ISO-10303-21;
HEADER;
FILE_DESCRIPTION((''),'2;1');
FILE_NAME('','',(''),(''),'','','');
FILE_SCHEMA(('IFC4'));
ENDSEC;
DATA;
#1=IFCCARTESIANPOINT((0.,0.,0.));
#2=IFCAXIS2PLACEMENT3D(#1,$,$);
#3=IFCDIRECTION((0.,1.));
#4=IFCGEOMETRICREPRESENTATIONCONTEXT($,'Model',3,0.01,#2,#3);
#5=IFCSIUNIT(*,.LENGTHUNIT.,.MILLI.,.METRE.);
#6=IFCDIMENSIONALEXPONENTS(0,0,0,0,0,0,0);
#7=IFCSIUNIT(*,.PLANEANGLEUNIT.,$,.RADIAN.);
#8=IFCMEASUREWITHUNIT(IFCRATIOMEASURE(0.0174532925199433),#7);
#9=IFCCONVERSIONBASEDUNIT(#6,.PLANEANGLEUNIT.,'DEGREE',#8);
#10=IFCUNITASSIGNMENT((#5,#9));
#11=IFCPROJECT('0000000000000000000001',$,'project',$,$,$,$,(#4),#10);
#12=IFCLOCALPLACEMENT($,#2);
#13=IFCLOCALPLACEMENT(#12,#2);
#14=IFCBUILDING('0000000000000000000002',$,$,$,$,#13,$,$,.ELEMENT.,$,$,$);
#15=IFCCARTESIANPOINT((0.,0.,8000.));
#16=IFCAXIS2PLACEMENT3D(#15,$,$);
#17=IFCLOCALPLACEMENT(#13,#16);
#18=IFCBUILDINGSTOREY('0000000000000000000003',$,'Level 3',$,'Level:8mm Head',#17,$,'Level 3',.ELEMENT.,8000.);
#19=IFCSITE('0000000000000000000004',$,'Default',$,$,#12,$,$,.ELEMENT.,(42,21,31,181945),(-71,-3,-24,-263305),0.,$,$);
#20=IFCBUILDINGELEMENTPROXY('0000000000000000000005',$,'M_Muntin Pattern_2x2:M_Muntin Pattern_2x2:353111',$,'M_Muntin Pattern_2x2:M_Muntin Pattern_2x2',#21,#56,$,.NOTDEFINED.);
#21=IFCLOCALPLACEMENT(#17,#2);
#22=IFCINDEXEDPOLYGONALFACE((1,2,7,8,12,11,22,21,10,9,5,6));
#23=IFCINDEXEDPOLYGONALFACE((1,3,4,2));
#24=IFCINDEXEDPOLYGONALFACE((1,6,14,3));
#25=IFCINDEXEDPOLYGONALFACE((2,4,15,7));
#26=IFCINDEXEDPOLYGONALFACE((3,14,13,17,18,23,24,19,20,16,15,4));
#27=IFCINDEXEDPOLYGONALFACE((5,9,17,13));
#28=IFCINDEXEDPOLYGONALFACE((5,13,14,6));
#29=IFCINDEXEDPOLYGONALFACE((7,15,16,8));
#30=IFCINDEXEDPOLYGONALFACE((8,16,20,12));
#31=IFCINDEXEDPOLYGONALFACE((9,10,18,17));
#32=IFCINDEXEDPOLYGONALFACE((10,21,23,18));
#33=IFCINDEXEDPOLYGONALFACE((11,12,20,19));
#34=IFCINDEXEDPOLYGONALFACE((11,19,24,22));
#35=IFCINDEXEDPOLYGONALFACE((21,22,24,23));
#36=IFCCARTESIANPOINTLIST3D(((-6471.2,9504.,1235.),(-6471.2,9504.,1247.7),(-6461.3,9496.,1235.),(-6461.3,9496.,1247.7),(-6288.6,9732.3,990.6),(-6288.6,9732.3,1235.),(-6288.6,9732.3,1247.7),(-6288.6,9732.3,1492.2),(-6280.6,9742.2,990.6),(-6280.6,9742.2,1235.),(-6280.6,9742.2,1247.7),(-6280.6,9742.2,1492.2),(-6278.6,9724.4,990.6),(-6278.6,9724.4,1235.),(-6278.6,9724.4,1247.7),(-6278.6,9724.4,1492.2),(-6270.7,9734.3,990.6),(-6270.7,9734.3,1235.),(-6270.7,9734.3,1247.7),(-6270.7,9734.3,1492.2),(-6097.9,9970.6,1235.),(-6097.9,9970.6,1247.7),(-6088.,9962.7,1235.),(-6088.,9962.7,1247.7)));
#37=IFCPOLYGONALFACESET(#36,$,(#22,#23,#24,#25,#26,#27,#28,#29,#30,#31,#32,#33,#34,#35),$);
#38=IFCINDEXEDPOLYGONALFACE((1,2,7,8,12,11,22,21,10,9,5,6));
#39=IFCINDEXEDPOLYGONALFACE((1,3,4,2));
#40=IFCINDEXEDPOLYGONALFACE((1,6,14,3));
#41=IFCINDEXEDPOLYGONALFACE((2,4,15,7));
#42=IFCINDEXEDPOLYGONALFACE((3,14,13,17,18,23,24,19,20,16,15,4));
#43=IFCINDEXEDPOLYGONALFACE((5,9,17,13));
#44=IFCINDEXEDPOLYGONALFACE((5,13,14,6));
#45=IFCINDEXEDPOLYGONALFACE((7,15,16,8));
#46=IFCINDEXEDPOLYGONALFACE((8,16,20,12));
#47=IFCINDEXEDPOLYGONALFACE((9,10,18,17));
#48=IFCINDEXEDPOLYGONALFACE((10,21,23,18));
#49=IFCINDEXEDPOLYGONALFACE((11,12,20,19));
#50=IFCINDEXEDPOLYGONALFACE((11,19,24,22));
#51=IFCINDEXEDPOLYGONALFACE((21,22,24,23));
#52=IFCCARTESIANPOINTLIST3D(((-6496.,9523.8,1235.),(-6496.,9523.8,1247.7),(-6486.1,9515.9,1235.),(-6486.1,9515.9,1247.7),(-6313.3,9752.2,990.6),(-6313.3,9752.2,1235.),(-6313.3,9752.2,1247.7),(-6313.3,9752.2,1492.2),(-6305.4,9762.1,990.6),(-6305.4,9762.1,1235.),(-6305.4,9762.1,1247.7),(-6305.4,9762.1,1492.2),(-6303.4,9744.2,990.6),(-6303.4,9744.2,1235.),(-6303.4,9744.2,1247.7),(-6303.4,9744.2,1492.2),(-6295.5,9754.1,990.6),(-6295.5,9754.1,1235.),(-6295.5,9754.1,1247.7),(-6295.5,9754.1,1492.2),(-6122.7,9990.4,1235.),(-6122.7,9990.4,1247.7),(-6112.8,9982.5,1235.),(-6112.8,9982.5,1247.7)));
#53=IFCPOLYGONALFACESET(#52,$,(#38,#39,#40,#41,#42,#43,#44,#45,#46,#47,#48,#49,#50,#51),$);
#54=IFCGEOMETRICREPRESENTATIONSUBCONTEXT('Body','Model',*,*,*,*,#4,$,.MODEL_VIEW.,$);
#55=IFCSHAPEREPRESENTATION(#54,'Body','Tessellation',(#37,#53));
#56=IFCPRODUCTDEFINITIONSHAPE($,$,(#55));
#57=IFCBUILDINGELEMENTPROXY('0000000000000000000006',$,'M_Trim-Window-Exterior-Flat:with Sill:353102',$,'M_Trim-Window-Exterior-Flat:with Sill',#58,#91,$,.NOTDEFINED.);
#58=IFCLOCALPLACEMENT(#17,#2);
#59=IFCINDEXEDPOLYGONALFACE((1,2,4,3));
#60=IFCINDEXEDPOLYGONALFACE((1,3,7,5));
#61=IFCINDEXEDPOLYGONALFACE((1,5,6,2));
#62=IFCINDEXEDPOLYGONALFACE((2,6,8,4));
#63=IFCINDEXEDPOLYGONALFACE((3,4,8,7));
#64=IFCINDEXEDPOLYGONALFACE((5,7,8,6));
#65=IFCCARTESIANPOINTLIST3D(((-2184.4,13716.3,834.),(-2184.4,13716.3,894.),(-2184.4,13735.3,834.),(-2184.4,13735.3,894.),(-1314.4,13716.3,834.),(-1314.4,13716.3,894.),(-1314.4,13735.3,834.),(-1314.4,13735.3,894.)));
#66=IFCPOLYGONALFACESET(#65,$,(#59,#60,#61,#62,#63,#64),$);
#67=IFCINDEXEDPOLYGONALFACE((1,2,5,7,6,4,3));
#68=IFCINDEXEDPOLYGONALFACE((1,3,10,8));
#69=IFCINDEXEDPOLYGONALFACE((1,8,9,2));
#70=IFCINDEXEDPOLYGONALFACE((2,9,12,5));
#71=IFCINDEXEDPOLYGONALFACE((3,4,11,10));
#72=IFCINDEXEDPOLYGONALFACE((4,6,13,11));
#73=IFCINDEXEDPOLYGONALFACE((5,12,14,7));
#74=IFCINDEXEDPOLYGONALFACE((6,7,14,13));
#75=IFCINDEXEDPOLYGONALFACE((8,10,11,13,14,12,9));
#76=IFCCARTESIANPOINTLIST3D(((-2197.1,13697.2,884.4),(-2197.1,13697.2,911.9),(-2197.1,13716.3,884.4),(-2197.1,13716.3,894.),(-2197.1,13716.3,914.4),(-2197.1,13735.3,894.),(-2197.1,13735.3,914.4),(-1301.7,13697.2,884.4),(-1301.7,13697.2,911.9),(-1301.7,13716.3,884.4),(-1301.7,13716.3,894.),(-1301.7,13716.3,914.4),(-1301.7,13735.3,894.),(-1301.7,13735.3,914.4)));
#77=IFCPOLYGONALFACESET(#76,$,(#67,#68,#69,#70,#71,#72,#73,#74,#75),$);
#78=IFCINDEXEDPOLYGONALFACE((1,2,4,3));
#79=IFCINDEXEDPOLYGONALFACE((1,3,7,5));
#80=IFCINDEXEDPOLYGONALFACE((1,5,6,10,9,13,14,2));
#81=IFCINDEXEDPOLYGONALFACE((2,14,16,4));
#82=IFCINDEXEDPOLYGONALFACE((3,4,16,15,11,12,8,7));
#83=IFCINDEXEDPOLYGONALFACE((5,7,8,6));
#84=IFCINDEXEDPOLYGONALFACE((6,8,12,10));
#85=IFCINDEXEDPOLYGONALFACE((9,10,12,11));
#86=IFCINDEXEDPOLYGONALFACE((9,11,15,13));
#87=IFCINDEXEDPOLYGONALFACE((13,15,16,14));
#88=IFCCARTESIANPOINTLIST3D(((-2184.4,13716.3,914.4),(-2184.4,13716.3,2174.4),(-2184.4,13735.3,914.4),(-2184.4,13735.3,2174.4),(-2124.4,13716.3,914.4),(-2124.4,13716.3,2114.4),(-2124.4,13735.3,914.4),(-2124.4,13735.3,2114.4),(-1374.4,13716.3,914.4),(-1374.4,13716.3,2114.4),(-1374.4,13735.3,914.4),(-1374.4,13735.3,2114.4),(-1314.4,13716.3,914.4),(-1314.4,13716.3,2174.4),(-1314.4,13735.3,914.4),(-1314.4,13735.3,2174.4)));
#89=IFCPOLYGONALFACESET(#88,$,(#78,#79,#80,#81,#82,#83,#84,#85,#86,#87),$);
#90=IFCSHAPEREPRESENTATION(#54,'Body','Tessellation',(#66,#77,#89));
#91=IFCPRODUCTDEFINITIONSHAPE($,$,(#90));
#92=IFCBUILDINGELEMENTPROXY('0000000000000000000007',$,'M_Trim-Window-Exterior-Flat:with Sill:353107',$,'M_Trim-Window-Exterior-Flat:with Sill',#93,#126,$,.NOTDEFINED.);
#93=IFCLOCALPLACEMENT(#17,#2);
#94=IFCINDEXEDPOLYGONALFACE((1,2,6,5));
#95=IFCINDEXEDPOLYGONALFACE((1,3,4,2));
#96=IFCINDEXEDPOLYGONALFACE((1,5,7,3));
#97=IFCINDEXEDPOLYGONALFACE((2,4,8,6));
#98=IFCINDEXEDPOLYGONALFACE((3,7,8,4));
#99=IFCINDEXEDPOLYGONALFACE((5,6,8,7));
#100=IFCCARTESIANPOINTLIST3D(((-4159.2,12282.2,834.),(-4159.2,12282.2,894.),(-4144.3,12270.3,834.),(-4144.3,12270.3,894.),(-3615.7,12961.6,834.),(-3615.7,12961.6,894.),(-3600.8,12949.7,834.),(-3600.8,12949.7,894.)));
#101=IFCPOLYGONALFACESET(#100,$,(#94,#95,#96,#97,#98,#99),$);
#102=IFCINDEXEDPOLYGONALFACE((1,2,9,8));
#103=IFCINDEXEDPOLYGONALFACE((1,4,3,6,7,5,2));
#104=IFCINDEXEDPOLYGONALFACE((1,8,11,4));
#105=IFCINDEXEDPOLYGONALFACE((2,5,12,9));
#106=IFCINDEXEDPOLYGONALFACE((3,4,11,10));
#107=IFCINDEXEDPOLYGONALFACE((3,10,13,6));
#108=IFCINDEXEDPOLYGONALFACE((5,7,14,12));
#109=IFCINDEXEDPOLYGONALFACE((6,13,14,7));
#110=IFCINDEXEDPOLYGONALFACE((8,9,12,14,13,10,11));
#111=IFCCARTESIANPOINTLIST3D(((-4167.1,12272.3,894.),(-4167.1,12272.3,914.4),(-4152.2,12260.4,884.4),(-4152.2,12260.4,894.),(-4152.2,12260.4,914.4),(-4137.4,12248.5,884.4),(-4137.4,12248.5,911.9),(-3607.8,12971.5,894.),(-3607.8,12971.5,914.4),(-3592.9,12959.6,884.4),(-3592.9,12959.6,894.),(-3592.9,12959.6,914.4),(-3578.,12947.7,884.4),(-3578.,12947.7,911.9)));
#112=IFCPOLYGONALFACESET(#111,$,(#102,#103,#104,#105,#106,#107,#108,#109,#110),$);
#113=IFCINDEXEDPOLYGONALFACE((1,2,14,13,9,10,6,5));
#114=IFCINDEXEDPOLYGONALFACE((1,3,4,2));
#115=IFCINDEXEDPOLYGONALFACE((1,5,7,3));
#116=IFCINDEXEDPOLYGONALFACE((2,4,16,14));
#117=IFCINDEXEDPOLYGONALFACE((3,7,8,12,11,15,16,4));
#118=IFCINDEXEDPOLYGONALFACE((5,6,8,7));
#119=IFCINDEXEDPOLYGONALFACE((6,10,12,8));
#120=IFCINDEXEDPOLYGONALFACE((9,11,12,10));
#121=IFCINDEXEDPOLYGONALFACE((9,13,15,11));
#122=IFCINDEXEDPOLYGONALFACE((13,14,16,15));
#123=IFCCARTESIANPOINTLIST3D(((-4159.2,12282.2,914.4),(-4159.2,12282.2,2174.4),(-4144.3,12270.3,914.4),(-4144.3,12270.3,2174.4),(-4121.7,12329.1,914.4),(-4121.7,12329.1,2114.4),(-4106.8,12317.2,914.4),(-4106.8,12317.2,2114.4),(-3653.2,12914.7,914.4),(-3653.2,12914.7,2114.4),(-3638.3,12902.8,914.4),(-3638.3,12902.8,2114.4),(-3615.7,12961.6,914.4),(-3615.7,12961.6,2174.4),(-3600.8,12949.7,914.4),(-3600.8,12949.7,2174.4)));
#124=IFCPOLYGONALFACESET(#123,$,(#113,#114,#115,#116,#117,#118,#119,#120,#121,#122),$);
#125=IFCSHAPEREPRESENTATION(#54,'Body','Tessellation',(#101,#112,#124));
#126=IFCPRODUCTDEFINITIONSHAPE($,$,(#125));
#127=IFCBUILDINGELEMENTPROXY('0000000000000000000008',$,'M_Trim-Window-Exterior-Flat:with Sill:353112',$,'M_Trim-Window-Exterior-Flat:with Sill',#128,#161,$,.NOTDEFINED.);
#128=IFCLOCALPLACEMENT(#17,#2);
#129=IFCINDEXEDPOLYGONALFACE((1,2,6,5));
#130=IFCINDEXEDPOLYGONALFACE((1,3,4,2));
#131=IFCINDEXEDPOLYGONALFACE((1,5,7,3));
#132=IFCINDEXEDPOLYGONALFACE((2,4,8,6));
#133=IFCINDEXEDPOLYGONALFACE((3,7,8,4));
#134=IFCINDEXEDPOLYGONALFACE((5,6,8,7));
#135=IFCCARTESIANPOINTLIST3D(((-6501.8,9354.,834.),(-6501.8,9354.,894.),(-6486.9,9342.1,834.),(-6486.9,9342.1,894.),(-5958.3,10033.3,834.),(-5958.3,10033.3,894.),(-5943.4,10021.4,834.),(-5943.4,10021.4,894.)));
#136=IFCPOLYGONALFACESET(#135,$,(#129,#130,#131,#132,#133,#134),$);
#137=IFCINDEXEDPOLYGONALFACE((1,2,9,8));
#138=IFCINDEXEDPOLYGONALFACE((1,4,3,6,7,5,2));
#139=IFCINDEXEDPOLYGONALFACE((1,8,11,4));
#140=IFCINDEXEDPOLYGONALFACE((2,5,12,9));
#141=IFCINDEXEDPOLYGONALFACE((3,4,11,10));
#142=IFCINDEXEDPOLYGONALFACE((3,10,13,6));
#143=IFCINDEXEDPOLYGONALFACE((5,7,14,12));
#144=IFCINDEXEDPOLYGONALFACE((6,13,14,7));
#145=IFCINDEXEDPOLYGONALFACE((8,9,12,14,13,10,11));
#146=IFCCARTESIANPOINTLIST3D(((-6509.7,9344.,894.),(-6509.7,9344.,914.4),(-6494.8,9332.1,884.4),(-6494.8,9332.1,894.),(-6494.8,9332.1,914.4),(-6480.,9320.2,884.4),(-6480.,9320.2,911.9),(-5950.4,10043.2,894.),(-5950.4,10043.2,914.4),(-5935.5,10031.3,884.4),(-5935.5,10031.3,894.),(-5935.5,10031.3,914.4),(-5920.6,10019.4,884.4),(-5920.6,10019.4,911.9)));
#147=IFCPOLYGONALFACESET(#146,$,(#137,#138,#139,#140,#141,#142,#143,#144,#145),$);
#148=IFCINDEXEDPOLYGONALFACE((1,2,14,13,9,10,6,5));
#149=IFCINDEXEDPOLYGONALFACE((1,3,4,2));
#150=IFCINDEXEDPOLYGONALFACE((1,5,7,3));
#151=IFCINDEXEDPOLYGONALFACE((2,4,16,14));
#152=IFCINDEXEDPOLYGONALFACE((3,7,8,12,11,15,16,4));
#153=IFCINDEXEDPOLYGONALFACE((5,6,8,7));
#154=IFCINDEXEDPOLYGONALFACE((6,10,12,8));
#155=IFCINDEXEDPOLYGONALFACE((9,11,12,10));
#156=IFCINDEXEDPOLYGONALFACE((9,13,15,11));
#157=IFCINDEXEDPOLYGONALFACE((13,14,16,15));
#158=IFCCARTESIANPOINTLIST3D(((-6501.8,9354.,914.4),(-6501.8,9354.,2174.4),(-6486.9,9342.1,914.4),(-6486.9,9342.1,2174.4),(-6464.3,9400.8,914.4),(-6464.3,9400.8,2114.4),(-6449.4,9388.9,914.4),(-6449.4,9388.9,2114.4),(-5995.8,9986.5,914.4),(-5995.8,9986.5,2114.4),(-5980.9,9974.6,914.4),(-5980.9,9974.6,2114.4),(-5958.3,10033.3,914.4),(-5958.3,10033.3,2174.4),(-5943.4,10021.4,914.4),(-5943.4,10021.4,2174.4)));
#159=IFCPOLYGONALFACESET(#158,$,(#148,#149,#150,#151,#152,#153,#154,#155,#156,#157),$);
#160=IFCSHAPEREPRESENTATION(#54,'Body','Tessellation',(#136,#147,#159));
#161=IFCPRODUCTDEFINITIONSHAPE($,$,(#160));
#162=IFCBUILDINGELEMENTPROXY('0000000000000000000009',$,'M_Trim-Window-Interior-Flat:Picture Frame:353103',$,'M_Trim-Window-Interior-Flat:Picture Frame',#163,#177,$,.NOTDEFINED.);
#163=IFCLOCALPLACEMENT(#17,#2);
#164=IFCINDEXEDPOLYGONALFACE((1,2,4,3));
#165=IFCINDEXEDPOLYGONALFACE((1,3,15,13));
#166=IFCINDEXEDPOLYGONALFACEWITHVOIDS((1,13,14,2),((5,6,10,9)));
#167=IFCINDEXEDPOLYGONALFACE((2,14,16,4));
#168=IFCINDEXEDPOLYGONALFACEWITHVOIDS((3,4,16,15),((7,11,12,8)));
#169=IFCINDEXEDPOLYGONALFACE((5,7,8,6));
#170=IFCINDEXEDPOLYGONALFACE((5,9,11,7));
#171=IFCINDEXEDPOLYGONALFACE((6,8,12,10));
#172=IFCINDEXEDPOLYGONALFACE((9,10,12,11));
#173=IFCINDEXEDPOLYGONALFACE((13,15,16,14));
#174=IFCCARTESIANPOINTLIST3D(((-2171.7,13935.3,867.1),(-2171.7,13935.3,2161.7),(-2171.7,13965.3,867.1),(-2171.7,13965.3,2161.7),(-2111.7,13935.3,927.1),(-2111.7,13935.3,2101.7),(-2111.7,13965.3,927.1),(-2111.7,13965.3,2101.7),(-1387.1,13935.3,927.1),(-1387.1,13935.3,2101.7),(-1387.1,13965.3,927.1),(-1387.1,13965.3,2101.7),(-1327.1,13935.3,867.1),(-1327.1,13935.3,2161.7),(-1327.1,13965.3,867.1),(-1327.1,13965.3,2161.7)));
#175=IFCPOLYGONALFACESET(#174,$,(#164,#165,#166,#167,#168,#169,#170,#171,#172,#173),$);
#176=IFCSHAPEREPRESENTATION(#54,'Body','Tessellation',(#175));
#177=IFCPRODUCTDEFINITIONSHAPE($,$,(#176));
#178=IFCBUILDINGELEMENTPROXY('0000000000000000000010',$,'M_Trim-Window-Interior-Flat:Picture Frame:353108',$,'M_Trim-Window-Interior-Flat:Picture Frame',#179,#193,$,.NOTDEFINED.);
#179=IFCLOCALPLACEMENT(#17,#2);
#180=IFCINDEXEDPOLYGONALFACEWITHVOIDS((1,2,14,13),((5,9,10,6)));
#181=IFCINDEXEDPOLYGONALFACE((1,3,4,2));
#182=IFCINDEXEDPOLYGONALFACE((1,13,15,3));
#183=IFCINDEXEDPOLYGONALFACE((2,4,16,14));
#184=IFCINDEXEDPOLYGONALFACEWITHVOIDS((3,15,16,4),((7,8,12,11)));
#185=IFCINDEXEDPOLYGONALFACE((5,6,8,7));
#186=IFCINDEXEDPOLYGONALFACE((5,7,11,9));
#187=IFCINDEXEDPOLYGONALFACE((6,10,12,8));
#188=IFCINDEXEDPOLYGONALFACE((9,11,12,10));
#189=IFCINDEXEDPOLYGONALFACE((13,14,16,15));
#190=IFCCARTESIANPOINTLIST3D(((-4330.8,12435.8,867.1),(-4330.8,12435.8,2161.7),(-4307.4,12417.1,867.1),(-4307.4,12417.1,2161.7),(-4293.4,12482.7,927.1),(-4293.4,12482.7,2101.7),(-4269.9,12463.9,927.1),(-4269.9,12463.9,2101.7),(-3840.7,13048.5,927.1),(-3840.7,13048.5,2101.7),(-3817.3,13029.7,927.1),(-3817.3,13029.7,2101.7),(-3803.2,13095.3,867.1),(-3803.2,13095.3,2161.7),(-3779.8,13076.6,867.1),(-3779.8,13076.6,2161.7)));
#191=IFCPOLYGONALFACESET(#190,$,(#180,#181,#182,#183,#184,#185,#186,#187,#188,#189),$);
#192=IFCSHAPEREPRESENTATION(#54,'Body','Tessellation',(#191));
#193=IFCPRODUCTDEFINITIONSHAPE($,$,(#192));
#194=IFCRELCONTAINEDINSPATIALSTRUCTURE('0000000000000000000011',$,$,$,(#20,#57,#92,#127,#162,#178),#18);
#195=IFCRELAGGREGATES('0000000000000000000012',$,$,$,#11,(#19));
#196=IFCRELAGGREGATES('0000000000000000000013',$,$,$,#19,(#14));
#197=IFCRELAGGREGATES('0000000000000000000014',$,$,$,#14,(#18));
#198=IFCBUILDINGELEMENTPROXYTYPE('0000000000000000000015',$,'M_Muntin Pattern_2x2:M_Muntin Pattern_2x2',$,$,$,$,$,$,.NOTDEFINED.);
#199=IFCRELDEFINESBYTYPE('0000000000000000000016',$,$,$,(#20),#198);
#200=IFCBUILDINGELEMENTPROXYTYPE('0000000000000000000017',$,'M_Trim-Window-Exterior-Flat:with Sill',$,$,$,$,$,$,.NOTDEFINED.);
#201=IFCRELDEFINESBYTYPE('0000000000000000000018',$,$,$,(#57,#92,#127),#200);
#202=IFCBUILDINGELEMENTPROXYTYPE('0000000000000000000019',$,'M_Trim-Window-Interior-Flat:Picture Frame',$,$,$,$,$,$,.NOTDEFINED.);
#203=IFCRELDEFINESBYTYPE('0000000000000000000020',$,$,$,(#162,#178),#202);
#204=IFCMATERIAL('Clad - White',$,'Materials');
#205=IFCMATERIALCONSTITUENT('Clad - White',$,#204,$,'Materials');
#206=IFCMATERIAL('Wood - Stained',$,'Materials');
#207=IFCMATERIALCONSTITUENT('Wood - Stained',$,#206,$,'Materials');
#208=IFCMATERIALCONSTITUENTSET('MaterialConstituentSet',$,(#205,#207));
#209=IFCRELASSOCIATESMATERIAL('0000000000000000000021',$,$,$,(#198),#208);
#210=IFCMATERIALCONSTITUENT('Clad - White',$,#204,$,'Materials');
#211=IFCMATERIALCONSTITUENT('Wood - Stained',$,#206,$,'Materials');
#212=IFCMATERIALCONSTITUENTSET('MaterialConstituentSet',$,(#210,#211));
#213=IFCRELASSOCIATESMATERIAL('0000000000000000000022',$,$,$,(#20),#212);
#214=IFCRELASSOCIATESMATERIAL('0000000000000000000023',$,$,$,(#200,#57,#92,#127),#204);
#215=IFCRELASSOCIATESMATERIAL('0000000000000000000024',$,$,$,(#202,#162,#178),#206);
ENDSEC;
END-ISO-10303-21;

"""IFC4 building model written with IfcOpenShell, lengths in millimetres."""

from ifc_helpers import new_model, entity, si_unit, converted_unit, direction, frame, frame_2d, origin, place, context, subcontext, project, spatial, polyline, rectangle, outline, extrude, source, transform, mapped, material, constituent, constituent_set, type_object, type_shapes, element, save


model = new_model("IFC4")

# Units and contexts
model_context = context("Model", 3, precision=0.01, world=origin(), true_north=direction((0.0, 1.0)))
body_context = subcontext(model_context, "Body", "Model", "MODEL_VIEW")
ifc_project = project(units=[si_unit("LENGTHUNIT", "METRE", prefix="MILLI"), converted_unit("PLANEANGLEUNIT", "DEGREE", entity("IfcRatioMeasure", 0.0174532925199433), si_unit("PLANEANGLEUNIT", "RADIAN"), dimensions=[0, 0, 0, 0, 0, 0, 0])], contexts=[model_context])

# Site, building, storey
site_placement = place(None, origin())
site = spatial("IfcSite", under=ifc_project, at=site_placement, Name="Default", CompositionType="ELEMENT", RefLatitude=(42, 21, 31, 181945), RefLongitude=(-71, -3, -24, -263305), RefElevation=0.0)
building_placement = place(site_placement, origin())
building = spatial("IfcBuilding", under=site, at=building_placement, CompositionType="ELEMENT")
storey_placement = place(building_placement, frame((0.0, 0.0, 8000.0)))
storey = spatial("IfcBuildingStorey", under=building, at=storey_placement, Name="Level 3", ObjectType="Level:8mm Head", LongName="Level 3", CompositionType="ELEMENT", Elevation=8000.0)

# Shared definitions
ifc_material_1 = material(Name="Wood - Stained", Category="Materials")

# Building element proxies
ifc_material_2 = material(Name="Clad - White", Category="Materials")
ifc_constituent_1 = constituent(ifc_material_2, Name="Clad - White", Category="Materials")
ifc_constituent_2 = constituent(ifc_material_1, Name="Wood - Stained", Category="Materials")
ifc_constituent_set_1 = constituent_set(constituents=[ifc_constituent_1, ifc_constituent_2], Name="MaterialConstituentSet")
building_element_proxy_type_1 = type_object("IfcBuildingElementProxyType", Name="M_Muntin Pattern_2x2:M_Muntin Pattern_2x2", PredefinedType="NOTDEFINED", material=ifc_constituent_set_1)
shared_shape_1 = source(origin(), body_context, "Body", "SweptSolid", [
    extrude(outline(polyline([(6.4, -6.4), (250.8, -6.4), (250.8, 6.3), (6.4, 6.3), (6.4, 298.8), (-6.3, 298.8), (-6.3, 6.3), (-250.8, 6.3), (-250.8, -6.4), (-6.3, -6.4), (-6.3, -298.8), (6.4, -298.8), (6.4, -6.4)])), frame((0.0, 9.5, 250.8), z_axis=(0.0, 1.0, 0.0), x_axis=(0.0, 0.0, 1.0)), (0.0, 0.0, 1.0), 12.7),
    extrude(outline(polyline([(6.4, -6.4), (250.8, -6.4), (250.8, 6.3), (6.4, 6.3), (6.4, 298.8), (-6.3, 298.8), (-6.3, 6.3), (-250.8, 6.3), (-250.8, -6.4), (-6.3, -6.4), (-6.3, -298.8), (6.4, -298.8), (6.4, -6.4)])), frame((0.0, -22.2, 250.8), z_axis=(0.0, 1.0, 0.0), x_axis=(0.0, 0.0, 1.0)), (0.0, 0.0, 1.0), 12.7),
])
type_shapes(building_element_proxy_type_1, [shared_shape_1])
ifc_constituent_3 = constituent(ifc_material_2, Name="Clad - White", Category="Materials")
ifc_constituent_4 = constituent(ifc_material_1, Name="Wood - Stained", Category="Materials")
ifc_constituent_set_2 = constituent_set(constituents=[ifc_constituent_3, ifc_constituent_4], Name="MaterialConstituentSet")
proxy_1_placement = place(storey_placement, frame((-6292.0, 9743.2, 990.6), z_axis=(0.0, 0.0, 1.0), x_axis=(-0.624695, -0.780869, 0.0)))
element("IfcBuildingElementProxy", 1, at=proxy_1_placement, inside=storey, type_object=building_element_proxy_type_1, material=ifc_constituent_set_2, Name="M_Muntin Pattern_2x2:M_Muntin Pattern_2x2:353111", ObjectType="M_Muntin Pattern_2x2:M_Muntin Pattern_2x2", PredefinedType="NOTDEFINED", context=body_context, shape_type="MappedRepresentation", body=[
    mapped(shared_shape_1, transform((0.0, 0.0, 0.0), scale=1.0)),
])
building_element_proxy_type_2 = type_object("IfcBuildingElementProxyType", Name="M_Trim-Window-Exterior-Flat:with Sill", PredefinedType="NOTDEFINED", material=ifc_material_2)
shared_shape_2 = source(origin(), body_context, "Body", "SweptSolid", [
    extrude(rectangle(XDim=870.0, YDim=60.0, at=frame_2d((0.0, 0.0), x_axis=(1.0, 0.0))), frame((0.0, -1250.4, 0.0), z_axis=(0.0, 0.0, 1.0), x_axis=(-1.0, 0.0, 0.0)), (0.0, 0.0, 1.0), 19.1),
    extrude(outline(polyline([(-19.0, -15.2), (0.0, -15.2), (0.0, -5.7), (19.0, -5.7), (19.0, 14.8), (0.0, 14.8), (-19.0, 12.3), (-19.0, -15.2)])), frame((-447.7, -1214.8, 19.0), z_axis=(1.0, 0.0, 0.0), x_axis=(0.0, 0.0, -1.0)), (0.0, 0.0, 1.0), 895.4),
    extrude(outline(polyline([(-645.0, -435.0), (615.0, -435.0), (615.0, -375.0), (-585.0, -375.0), (-585.0, 375.0), (615.0, 375.0), (615.0, 435.0), (-645.0, 435.0), (-645.0, -435.0)])), frame((0.0, -585.0, 0.0), z_axis=(0.0, 0.0, 1.0), x_axis=(0.0, -1.0, 0.0)), (0.0, 0.0, 1.0), 19.1),
])
type_shapes(building_element_proxy_type_2, [shared_shape_2])
for number, where, z_axis, x_axis, name in (
    (2, (-1749.4, 13735.3, 2114.4), (0.0, -1.0, 0.0), (1.0, 0.0, 0.0), "M_Trim-Window-Exterior-Flat:with Sill:353102"),
    (3, (-3887.4, 12621.9, 2114.4), (0.780869, -0.624695, 0.0), (0.624695, 0.780869, 0.0), "M_Trim-Window-Exterior-Flat:with Sill:353107"),
    (4, (-6230.0, 9693.6, 2114.4), (0.780869, -0.624695, 0.0), (0.624695, 0.780869, 0.0), "M_Trim-Window-Exterior-Flat:with Sill:353112"),
):
    element("IfcBuildingElementProxy", number, at=place(storey_placement, frame(where, z_axis=z_axis, x_axis=x_axis)), inside=storey, type_object=building_element_proxy_type_2, material=ifc_material_2, Name=name, ObjectType="M_Trim-Window-Exterior-Flat:with Sill", PredefinedType="NOTDEFINED", context=body_context, shape_type="MappedRepresentation", body=[
        mapped(shared_shape_2, transform((0.0, 0.0, 0.0), scale=1.0)),
    ])
building_element_proxy_type_3 = type_object("IfcBuildingElementProxyType", Name="M_Trim-Window-Interior-Flat:Picture Frame", PredefinedType="NOTDEFINED", material=ifc_material_1)
shared_shape_3 = source(origin(), body_context, "Body", "SweptSolid", [
    extrude(outline(polyline([(-422.3, -647.3), (422.3, -647.3), (422.3, 647.3), (-422.3, 647.3), (-422.3, -647.3)]), holes=[polyline([(-362.3, -587.3), (-362.3, 587.3), (362.3, 587.3), (362.3, -587.3), (-362.3, -587.3)])]), frame((0.0, -600.0, 0.0), z_axis=(0.0, 0.0, 1.0), x_axis=(-1.0, 0.0, 0.0)), (0.0, 0.0, 1.0), 30.0),
])
type_shapes(building_element_proxy_type_3, [shared_shape_3])
for number, where, z_axis, x_axis, name in (
    (5, (-1749.4, 13935.3, 2114.4), (0.0, 1.0, 0.0), (-1.0, 0.0, 0.0), "M_Trim-Window-Interior-Flat:Picture Frame:353103"),
    (6, (-4043.6, 12746.8, 2114.4), (-0.780869, 0.624695, 0.0), (-0.624695, -0.780869, 0.0), "M_Trim-Window-Interior-Flat:Picture Frame:353108"),
):
    element("IfcBuildingElementProxy", number, at=place(storey_placement, frame(where, z_axis=z_axis, x_axis=x_axis)), inside=storey, type_object=building_element_proxy_type_3, material=ifc_material_1, Name=name, ObjectType="M_Trim-Window-Interior-Flat:Picture Frame", PredefinedType="NOTDEFINED", context=body_context, shape_type="MappedRepresentation", body=[
        mapped(shared_shape_3, transform((0.0, 0.0, 0.0), scale=1.0)),
    ])

save(model, "model.ifc")
